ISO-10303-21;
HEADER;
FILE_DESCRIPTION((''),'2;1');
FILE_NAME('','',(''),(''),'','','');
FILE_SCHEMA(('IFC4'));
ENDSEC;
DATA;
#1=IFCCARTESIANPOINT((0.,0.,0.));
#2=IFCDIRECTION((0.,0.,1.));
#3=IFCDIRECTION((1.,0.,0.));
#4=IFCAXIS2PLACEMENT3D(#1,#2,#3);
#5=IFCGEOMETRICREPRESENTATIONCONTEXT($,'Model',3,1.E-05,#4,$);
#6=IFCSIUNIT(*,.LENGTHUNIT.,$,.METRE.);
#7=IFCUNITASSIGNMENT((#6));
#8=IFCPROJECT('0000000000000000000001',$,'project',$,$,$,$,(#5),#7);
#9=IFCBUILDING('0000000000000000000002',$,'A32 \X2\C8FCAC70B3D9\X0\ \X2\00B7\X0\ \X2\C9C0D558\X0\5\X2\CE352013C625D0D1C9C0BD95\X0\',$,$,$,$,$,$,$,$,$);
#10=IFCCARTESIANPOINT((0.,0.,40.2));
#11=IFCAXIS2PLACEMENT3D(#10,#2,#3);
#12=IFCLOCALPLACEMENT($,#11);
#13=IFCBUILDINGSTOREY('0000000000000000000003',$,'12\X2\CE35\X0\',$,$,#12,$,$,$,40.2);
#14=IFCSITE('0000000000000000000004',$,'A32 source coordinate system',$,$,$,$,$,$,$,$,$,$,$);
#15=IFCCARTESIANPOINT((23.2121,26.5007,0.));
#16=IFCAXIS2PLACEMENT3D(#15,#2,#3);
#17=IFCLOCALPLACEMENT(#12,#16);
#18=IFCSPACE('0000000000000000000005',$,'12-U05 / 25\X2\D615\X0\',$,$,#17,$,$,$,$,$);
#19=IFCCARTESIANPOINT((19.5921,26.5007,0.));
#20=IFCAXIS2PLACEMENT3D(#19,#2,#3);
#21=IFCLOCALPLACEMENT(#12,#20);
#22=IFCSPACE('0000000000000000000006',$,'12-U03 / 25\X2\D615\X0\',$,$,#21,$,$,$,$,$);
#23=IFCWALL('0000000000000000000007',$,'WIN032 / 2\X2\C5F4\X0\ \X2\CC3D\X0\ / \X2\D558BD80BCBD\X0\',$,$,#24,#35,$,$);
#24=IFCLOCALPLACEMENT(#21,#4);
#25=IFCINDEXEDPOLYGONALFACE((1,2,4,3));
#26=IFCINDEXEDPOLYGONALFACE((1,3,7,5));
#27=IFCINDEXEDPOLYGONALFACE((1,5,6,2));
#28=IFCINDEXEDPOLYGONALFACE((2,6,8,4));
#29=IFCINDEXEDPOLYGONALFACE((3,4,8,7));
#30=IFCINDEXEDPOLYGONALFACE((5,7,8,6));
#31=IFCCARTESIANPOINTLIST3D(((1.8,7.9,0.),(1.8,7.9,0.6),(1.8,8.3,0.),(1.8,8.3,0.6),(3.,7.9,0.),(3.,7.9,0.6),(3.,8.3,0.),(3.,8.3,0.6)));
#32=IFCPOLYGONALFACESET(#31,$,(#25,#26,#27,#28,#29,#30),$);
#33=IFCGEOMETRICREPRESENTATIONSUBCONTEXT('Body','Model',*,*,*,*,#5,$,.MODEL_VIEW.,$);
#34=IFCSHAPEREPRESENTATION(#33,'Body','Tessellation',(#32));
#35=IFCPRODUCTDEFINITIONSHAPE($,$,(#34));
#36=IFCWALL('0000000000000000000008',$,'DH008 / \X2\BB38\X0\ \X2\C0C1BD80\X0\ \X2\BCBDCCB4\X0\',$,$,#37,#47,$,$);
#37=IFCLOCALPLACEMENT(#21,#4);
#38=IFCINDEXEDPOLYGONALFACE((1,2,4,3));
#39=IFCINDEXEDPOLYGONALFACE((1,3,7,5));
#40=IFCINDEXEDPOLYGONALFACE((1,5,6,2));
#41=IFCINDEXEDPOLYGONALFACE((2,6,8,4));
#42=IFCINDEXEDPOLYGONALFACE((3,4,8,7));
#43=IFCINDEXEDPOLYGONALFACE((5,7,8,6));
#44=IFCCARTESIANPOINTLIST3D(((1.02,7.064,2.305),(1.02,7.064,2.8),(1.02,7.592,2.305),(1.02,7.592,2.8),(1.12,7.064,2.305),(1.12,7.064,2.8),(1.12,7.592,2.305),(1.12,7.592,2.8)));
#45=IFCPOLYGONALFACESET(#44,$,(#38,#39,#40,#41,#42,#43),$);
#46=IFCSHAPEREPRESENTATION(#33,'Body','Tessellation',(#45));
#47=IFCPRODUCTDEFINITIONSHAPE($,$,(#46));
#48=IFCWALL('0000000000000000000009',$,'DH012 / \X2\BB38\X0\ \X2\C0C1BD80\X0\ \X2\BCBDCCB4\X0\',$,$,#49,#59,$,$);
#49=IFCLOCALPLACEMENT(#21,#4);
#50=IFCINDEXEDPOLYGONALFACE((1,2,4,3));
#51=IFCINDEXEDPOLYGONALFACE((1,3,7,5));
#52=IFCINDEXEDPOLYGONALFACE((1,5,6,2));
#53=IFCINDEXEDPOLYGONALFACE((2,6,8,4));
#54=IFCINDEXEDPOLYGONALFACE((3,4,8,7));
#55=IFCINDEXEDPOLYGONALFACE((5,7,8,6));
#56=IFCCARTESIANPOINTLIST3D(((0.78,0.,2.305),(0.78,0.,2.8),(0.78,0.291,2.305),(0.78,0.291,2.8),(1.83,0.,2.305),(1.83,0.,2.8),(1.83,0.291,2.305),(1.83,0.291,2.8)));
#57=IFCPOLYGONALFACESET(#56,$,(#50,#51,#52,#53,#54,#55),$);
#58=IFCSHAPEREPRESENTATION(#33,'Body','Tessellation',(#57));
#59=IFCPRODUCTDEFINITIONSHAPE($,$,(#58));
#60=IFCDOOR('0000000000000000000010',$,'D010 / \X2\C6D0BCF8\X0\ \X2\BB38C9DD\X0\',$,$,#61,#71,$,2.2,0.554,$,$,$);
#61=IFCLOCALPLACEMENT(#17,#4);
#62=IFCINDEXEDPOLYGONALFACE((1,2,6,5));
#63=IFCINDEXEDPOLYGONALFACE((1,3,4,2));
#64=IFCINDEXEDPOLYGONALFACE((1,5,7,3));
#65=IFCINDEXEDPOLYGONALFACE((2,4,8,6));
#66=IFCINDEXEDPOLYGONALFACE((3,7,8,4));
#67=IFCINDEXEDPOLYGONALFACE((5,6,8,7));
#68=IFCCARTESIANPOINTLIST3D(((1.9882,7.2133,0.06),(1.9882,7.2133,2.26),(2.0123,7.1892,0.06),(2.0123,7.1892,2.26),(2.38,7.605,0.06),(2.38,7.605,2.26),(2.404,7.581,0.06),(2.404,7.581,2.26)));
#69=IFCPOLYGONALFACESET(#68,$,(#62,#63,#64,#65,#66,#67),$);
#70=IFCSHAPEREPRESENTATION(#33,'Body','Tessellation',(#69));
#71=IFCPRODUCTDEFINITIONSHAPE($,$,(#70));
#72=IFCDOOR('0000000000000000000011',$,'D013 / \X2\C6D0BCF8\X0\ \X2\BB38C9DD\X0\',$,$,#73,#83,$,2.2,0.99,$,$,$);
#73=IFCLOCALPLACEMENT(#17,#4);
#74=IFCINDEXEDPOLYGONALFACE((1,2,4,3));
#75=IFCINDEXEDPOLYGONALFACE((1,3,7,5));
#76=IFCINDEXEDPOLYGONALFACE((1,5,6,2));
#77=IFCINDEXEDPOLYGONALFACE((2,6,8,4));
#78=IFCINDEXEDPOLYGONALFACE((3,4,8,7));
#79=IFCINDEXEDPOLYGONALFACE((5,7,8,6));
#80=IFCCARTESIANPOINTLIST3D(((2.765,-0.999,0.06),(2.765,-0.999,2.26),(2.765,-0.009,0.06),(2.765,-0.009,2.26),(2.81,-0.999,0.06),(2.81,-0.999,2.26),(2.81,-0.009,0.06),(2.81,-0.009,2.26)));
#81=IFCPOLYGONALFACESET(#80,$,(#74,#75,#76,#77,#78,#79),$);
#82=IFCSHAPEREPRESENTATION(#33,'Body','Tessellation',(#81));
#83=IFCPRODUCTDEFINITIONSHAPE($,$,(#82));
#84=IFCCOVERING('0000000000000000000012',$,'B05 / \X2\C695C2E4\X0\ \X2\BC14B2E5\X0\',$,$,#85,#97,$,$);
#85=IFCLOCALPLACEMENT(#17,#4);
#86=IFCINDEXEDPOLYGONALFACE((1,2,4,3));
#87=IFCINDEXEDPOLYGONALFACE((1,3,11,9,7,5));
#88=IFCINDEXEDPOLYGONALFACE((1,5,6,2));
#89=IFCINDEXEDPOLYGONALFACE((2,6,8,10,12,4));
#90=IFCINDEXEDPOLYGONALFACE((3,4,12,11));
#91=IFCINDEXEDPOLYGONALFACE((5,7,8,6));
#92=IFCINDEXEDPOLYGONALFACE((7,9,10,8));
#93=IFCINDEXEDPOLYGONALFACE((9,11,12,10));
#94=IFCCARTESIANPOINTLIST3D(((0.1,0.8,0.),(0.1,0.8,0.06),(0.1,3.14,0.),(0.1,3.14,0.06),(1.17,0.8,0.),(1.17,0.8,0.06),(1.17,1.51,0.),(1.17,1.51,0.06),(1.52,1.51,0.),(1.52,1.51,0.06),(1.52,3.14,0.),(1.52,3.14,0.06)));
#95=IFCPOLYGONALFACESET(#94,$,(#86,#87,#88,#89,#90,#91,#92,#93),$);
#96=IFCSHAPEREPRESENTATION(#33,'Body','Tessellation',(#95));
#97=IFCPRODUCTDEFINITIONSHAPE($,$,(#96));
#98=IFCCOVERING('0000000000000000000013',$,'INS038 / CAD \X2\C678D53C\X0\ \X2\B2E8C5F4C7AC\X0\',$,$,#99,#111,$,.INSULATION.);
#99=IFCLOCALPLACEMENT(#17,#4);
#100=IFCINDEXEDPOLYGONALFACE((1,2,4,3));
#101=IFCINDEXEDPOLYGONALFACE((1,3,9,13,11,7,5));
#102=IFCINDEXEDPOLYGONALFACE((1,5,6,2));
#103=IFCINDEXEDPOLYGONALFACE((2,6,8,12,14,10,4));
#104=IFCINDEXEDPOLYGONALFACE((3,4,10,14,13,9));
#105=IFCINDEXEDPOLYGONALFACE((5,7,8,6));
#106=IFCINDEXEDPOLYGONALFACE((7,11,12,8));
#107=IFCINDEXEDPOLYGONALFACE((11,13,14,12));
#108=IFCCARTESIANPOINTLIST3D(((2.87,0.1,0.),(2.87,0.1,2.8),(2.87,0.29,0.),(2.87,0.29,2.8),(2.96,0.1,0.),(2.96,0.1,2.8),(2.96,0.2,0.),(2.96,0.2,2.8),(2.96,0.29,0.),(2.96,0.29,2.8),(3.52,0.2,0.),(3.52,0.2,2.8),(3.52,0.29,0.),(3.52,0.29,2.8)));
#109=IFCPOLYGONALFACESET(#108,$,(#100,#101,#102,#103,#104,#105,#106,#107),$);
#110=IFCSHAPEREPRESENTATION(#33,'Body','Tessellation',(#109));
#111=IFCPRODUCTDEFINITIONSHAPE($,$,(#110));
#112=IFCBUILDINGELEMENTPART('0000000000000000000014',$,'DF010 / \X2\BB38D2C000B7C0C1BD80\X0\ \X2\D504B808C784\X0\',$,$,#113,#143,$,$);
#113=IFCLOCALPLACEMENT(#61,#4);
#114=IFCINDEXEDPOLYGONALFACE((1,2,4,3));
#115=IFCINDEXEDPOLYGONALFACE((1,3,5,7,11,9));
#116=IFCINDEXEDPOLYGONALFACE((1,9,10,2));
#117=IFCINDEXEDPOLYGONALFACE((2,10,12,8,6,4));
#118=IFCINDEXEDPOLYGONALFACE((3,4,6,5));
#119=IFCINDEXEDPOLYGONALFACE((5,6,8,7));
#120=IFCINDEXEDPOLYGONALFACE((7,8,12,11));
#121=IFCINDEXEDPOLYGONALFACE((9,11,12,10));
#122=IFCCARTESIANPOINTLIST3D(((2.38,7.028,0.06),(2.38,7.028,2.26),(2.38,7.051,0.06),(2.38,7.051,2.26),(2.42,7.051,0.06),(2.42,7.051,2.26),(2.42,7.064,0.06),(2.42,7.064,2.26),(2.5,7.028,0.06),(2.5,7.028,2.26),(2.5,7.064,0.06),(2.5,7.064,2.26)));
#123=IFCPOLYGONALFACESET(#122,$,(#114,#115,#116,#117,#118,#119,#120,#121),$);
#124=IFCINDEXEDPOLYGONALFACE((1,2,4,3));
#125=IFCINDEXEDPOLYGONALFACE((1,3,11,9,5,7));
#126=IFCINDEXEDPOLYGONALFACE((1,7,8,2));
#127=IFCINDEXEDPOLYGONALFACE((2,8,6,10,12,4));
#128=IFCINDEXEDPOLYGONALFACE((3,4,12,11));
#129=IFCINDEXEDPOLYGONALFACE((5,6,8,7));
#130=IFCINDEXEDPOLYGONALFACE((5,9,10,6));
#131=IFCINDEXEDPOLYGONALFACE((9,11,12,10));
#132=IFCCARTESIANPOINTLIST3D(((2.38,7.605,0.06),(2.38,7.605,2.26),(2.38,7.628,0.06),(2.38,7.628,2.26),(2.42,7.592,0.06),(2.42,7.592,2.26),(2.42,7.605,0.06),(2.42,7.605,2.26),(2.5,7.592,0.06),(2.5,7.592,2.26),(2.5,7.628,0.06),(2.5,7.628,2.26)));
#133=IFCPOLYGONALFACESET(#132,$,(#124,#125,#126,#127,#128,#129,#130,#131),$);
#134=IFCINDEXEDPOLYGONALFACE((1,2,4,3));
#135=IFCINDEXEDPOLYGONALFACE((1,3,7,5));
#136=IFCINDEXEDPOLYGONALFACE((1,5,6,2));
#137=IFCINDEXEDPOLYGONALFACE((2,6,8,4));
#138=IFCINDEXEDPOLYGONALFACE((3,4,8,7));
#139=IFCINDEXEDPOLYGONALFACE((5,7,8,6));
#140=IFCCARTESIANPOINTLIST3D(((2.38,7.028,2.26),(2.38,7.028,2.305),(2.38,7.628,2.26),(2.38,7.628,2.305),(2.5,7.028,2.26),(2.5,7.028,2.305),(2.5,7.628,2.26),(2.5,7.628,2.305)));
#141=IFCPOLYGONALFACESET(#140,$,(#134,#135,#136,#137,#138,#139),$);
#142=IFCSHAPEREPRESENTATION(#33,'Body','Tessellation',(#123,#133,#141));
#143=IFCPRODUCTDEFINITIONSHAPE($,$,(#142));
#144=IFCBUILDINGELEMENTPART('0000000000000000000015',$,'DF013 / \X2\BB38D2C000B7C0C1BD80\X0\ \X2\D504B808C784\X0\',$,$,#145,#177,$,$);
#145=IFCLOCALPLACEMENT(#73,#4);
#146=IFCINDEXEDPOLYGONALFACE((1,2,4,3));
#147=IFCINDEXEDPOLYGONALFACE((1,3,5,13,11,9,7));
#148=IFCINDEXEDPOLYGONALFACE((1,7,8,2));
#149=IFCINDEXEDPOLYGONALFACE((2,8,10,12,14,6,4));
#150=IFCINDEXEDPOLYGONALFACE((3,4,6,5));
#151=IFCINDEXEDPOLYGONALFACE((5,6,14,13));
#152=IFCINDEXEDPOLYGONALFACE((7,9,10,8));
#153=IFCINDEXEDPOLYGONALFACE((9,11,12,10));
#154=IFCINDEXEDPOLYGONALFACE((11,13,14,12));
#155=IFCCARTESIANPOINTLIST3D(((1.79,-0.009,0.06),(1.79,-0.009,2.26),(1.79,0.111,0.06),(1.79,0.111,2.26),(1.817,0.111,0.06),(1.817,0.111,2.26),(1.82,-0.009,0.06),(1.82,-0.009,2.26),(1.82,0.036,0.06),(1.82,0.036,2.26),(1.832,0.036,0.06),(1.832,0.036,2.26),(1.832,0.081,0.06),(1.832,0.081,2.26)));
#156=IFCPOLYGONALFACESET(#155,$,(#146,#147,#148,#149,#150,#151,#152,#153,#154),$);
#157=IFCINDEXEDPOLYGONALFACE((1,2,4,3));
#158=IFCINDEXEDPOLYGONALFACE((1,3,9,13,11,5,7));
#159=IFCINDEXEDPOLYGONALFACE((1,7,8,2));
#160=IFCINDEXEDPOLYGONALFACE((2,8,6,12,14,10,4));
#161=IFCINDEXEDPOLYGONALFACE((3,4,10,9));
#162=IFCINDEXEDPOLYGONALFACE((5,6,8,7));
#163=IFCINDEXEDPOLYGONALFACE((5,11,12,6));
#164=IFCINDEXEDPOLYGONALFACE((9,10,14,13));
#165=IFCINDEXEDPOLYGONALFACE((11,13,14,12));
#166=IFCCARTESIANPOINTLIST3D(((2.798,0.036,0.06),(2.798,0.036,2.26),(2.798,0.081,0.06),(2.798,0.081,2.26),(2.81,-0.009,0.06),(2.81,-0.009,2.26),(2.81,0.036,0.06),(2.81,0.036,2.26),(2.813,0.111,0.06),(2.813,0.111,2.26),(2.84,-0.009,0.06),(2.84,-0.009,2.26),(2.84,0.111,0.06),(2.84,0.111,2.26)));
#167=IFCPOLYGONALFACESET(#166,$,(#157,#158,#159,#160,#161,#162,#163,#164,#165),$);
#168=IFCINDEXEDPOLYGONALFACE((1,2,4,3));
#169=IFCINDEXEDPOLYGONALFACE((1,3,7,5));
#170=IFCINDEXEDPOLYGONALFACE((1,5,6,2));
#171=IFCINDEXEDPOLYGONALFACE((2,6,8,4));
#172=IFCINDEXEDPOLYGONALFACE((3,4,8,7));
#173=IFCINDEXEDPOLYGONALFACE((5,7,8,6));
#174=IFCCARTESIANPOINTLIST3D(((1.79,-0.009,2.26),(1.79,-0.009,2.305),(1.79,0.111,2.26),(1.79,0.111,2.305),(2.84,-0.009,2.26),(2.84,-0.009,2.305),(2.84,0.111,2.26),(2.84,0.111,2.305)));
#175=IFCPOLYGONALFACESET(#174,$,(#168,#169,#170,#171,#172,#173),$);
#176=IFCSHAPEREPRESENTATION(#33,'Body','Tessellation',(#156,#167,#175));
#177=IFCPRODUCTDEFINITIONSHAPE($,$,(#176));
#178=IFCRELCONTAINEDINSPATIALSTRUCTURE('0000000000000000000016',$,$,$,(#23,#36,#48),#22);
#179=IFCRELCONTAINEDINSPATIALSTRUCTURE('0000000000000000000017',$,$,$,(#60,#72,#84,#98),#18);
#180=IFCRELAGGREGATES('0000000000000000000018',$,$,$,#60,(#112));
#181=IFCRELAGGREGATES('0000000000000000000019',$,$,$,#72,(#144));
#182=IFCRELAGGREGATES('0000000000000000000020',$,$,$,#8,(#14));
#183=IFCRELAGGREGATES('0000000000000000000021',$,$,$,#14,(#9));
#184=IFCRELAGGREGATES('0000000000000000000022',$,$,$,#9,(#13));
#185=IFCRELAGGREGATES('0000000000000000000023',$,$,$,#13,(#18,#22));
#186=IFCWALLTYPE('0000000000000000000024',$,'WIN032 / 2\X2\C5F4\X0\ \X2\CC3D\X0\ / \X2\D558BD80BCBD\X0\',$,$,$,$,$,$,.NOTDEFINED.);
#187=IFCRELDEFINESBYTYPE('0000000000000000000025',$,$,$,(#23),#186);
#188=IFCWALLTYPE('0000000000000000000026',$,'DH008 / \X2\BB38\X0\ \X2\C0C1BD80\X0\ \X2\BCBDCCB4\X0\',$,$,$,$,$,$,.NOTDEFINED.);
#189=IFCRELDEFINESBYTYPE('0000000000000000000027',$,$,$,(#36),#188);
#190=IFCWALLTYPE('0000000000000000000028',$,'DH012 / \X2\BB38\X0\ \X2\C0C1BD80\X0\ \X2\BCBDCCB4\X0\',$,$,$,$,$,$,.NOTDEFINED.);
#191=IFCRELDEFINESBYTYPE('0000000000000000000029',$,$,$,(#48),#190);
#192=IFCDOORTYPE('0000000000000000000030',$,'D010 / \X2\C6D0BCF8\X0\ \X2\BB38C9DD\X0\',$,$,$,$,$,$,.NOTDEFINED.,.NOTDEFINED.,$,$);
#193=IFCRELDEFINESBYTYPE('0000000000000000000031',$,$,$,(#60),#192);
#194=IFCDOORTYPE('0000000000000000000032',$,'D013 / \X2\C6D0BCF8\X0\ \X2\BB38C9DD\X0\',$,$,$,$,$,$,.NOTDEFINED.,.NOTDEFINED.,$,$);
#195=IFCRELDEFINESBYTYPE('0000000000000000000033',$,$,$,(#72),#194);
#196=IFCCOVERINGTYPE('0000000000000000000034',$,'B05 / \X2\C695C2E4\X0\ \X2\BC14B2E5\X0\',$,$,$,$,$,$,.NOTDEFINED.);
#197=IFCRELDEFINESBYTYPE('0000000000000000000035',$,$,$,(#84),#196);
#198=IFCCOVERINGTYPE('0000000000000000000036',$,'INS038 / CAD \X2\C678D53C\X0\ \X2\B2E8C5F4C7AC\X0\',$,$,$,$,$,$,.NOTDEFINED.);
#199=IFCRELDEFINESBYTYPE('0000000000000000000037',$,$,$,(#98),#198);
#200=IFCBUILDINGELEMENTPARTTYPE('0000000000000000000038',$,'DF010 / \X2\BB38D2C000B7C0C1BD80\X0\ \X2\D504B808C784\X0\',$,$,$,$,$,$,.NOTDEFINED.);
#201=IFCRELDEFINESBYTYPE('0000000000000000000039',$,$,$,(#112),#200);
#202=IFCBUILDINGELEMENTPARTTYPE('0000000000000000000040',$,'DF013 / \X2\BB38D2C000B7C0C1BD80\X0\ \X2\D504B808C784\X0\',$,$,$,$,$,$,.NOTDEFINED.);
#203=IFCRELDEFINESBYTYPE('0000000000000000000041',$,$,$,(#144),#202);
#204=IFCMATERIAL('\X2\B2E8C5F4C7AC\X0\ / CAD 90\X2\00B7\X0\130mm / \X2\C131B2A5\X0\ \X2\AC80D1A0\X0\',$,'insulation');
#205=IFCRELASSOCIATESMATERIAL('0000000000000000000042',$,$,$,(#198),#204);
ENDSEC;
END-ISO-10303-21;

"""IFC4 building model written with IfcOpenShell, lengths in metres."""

from ifc_helpers import new_model, si_unit, frame, origin, origin_with_axes, place, context, subcontext, project, spatial, polyline, outline, extrude, source, transform, mapped, material, type_object, type_shapes, element, aggregate, save


model = new_model("IFC4")

# Units and contexts
model_context = context("Model", 3, precision=1e-05, world=origin_with_axes())
body_context = subcontext(model_context, "Body", "Model", "MODEL_VIEW")
ifc_project = project(units=[si_unit("LENGTHUNIT", "METRE")], contexts=[model_context])

# Site, building, storey, space
storey_placement = place(None, frame((0.0, 0.0, 40.2), z_axis=(0.0, 0.0, 1.0), x_axis=(1.0, 0.0, 0.0)))
space_1_placement = place(storey_placement, frame((23.2121, 26.5007, 0.0), z_axis=(0.0, 0.0, 1.0), x_axis=(1.0, 0.0, 0.0)))
site = spatial("IfcSite", under=ifc_project, Name="A32 source coordinate system")
building = spatial("IfcBuilding", under=site, Name="A32 주거동 · 지하5층–옥탑지붕")
storey = spatial("IfcBuildingStorey", under=building, at=storey_placement, Name="12층", Elevation=40.2)
space_1 = spatial("IfcSpace", under=storey, at=space_1_placement, Name="12-U05 / 25형")

# Shared definitions
space_2_placement = place(storey_placement, frame((19.5921, 26.5007, 0.0), z_axis=(0.0, 0.0, 1.0), x_axis=(1.0, 0.0, 0.0)))
space_2 = spatial("IfcSpace", under=storey, at=space_2_placement, Name="12-U03 / 25형")

# Walls
wall_type_1 = type_object("IfcWallType", Name="WIN032 / 2열 창 / 하부벽", PredefinedType="NOTDEFINED")
shared_shape_1 = source(origin(), body_context, "Body", "SweptSolid", [
    extrude(outline(polyline([(3.0, 7.9), (1.8, 7.9), (1.8, 8.3), (3.0, 8.3), (3.0, 7.9)])), origin(), (0.0, 0.0, 1.0), 0.6),
])
type_shapes(wall_type_1, [shared_shape_1])
wall_1_placement = place(space_2_placement, origin_with_axes())
element("IfcWall", 1, at=wall_1_placement, inside=space_2, type_object=wall_type_1, Name="WIN032 / 2열 창 / 하부벽", context=body_context, shape_type="MappedRepresentation", body=[
    mapped(shared_shape_1, transform((0.0, 0.0, 0.0), scale=1.0)),
])
wall_type_2 = type_object("IfcWallType", Name="DH008 / 문 상부 벽체", PredefinedType="NOTDEFINED")
shared_shape_2 = source(origin(), body_context, "Body", "SweptSolid", [
    extrude(outline(polyline([(1.12, 7.064), (1.02, 7.064), (1.02, 7.592), (1.12, 7.592), (1.12, 7.064)])), frame((0.0, 0.0, 2.305)), (0.0, 0.0, 1.0), 0.495),
])
type_shapes(wall_type_2, [shared_shape_2])
wall_2_placement = place(space_2_placement, origin_with_axes())
element("IfcWall", 2, at=wall_2_placement, inside=space_2, type_object=wall_type_2, Name="DH008 / 문 상부 벽체", context=body_context, shape_type="MappedRepresentation", body=[
    mapped(shared_shape_2, transform((0.0, 0.0, 0.0), scale=1.0)),
])
wall_type_3 = type_object("IfcWallType", Name="DH012 / 문 상부 벽체", PredefinedType="NOTDEFINED")
shared_shape_3 = source(origin(), body_context, "Body", "SweptSolid", [
    extrude(outline(polyline([(0.78, 0.0), (0.78, 0.291), (1.83, 0.291), (1.83, 0.0), (0.78, 0.0)])), frame((0.0, 0.0, 2.305)), (0.0, 0.0, 1.0), 0.495),
])
type_shapes(wall_type_3, [shared_shape_3])
wall_3_placement = place(space_2_placement, origin_with_axes())
element("IfcWall", 3, at=wall_3_placement, inside=space_2, type_object=wall_type_3, Name="DH012 / 문 상부 벽체", context=body_context, shape_type="MappedRepresentation", body=[
    mapped(shared_shape_3, transform((0.0, 0.0, 0.0), scale=1.0)),
])

# Doors
door_type_1 = type_object("IfcDoorType", Name="D010 / 원본 문짝", OperationType="NOTDEFINED", PredefinedType="NOTDEFINED")
shared_shape_4 = source(origin(), body_context, "Body", "SweptSolid", [
    extrude(outline(polyline([(2.0123, 7.1892), (1.9882, 7.2133), (2.38, 7.605), (2.404, 7.581), (2.0123, 7.1892)])), frame((0.0, 0.0, 0.06)), (0.0, 0.0, 1.0), 2.2),
])
type_shapes(door_type_1, [shared_shape_4])
door_1_placement = place(space_1_placement, origin_with_axes())
door_1 = element("IfcDoor", 4, at=door_1_placement, inside=space_1, type_object=door_type_1, Name="D010 / 원본 문짝", OverallHeight=2.2, OverallWidth=0.554, context=body_context, shape_type="MappedRepresentation", body=[
    mapped(shared_shape_4, transform((0.0, 0.0, 0.0), scale=1.0)),
])
door_type_2 = type_object("IfcDoorType", Name="D013 / 원본 문짝", OperationType="NOTDEFINED", PredefinedType="NOTDEFINED")
shared_shape_5 = source(origin(), body_context, "Body", "SweptSolid", [
    extrude(outline(polyline([(2.81, -0.009), (2.81, -0.999), (2.765, -0.999), (2.765, -0.009), (2.81, -0.009)])), frame((0.0, 0.0, 0.06)), (0.0, 0.0, 1.0), 2.2),
])
type_shapes(door_type_2, [shared_shape_5])
door_2_placement = place(space_1_placement, origin_with_axes())
door_2 = element("IfcDoor", 5, at=door_2_placement, inside=space_1, type_object=door_type_2, Name="D013 / 원본 문짝", OverallHeight=2.2, OverallWidth=0.99, context=body_context, shape_type="MappedRepresentation", body=[
    mapped(shared_shape_5, transform((0.0, 0.0, 0.0), scale=1.0)),
])

# Coverings
covering_type_1 = type_object("IfcCoveringType", Name="B05 / 욕실 바닥", PredefinedType="NOTDEFINED")
shared_shape_6 = source(origin(), body_context, "Body", "SweptSolid", [
    extrude(outline(polyline([(0.1, 3.14), (1.52, 3.14), (1.52, 1.51), (1.17, 1.51), (1.17, 0.8), (0.1, 0.8), (0.1, 3.14)])), origin(), (0.0, 0.0, 1.0), 0.06),
])
type_shapes(covering_type_1, [shared_shape_6])
covering_1_placement = place(space_1_placement, origin_with_axes())
element("IfcCovering", 6, at=covering_1_placement, inside=space_1, type_object=covering_type_1, Name="B05 / 욕실 바닥", context=body_context, shape_type="MappedRepresentation", body=[
    mapped(shared_shape_6, transform((0.0, 0.0, 0.0), scale=1.0)),
])
ifc_material = material(Name="단열재 / CAD 90·130mm / 성능 검토", Category="insulation")
covering_type_2 = type_object("IfcCoveringType", Name="INS038 / CAD 외피 단열재", PredefinedType="NOTDEFINED", material=ifc_material)
shared_shape_7 = source(origin(), body_context, "Body", "SweptSolid", [
    extrude(outline(polyline([(2.96, 0.2), (2.96, 0.1), (2.87, 0.1), (2.87, 0.29), (2.96, 0.29), (3.52, 0.29), (3.52, 0.2), (2.96, 0.2)])), origin(), (0.0, 0.0, 1.0), 2.8),
])
type_shapes(covering_type_2, [shared_shape_7])
covering_2_placement = place(space_1_placement, origin_with_axes())
element("IfcCovering", 7, at=covering_2_placement, inside=space_1, type_object=covering_type_2, Name="INS038 / CAD 외피 단열재", PredefinedType="INSULATION", context=body_context, shape_type="MappedRepresentation", body=[
    mapped(shared_shape_7, transform((0.0, 0.0, 0.0), scale=1.0)),
])

# Building element parts
building_element_part_type_1 = type_object("IfcBuildingElementPartType", Name="DF010 / 문틀·상부 프레임", PredefinedType="NOTDEFINED")
shared_shape_8 = source(origin(), body_context, "Body", "SweptSolid", [
    extrude(outline(polyline([(2.38, 7.028), (2.38, 7.051), (2.42, 7.051), (2.42, 7.064), (2.5, 7.064), (2.5, 7.028), (2.38, 7.028)])), frame((0.0, 0.0, 0.06)), (0.0, 0.0, 1.0), 2.2),
    extrude(outline(polyline([(2.5, 7.592), (2.42, 7.592), (2.42, 7.605), (2.38, 7.605), (2.38, 7.628), (2.5, 7.628), (2.5, 7.592)])), frame((0.0, 0.0, 0.06)), (0.0, 0.0, 1.0), 2.2),
    extrude(outline(polyline([(2.38, 7.028), (2.38, 7.628), (2.5, 7.628), (2.5, 7.028), (2.38, 7.028)])), frame((0.0, 0.0, 2.26)), (0.0, 0.0, 1.0), 0.045),
])
type_shapes(building_element_part_type_1, [shared_shape_8])
building_element_part_1_placement = place(door_1_placement, origin_with_axes())
building_element_part_1 = element("IfcBuildingElementPart", 8, at=building_element_part_1_placement, type_object=building_element_part_type_1, Name="DF010 / 문틀·상부 프레임", context=body_context, shape_type="MappedRepresentation", body=[
    mapped(shared_shape_8, transform((0.0, 0.0, 0.0), scale=1.0)),
])
aggregate(door_1, [building_element_part_1])
building_element_part_type_2 = type_object("IfcBuildingElementPartType", Name="DF013 / 문틀·상부 프레임", PredefinedType="NOTDEFINED")
shared_shape_9 = source(origin(), body_context, "Body", "SweptSolid", [
    extrude(outline(polyline([(1.79, 0.111), (1.817, 0.111), (1.832, 0.081), (1.832, 0.036), (1.82, 0.036), (1.82, -0.009), (1.79, -0.009), (1.79, 0.111)])), frame((0.0, 0.0, 0.06)), (0.0, 0.0, 1.0), 2.2),
    extrude(outline(polyline([(2.81, -0.009), (2.81, 0.036), (2.798, 0.036), (2.798, 0.081), (2.813, 0.111), (2.84, 0.111), (2.84, -0.009), (2.81, -0.009)])), frame((0.0, 0.0, 0.06)), (0.0, 0.0, 1.0), 2.2),
    extrude(outline(polyline([(1.79, -0.009), (1.79, 0.111), (2.84, 0.111), (2.84, -0.009), (1.79, -0.009)])), frame((0.0, 0.0, 2.26)), (0.0, 0.0, 1.0), 0.045),
])
type_shapes(building_element_part_type_2, [shared_shape_9])
building_element_part_2_placement = place(door_2_placement, origin_with_axes())
building_element_part_2 = element("IfcBuildingElementPart", 9, at=building_element_part_2_placement, type_object=building_element_part_type_2, Name="DF013 / 문틀·상부 프레임", context=body_context, shape_type="MappedRepresentation", body=[
    mapped(shared_shape_9, transform((0.0, 0.0, 0.0), scale=1.0)),
])
aggregate(door_2, [building_element_part_2])

save(model, "model.ifc")
